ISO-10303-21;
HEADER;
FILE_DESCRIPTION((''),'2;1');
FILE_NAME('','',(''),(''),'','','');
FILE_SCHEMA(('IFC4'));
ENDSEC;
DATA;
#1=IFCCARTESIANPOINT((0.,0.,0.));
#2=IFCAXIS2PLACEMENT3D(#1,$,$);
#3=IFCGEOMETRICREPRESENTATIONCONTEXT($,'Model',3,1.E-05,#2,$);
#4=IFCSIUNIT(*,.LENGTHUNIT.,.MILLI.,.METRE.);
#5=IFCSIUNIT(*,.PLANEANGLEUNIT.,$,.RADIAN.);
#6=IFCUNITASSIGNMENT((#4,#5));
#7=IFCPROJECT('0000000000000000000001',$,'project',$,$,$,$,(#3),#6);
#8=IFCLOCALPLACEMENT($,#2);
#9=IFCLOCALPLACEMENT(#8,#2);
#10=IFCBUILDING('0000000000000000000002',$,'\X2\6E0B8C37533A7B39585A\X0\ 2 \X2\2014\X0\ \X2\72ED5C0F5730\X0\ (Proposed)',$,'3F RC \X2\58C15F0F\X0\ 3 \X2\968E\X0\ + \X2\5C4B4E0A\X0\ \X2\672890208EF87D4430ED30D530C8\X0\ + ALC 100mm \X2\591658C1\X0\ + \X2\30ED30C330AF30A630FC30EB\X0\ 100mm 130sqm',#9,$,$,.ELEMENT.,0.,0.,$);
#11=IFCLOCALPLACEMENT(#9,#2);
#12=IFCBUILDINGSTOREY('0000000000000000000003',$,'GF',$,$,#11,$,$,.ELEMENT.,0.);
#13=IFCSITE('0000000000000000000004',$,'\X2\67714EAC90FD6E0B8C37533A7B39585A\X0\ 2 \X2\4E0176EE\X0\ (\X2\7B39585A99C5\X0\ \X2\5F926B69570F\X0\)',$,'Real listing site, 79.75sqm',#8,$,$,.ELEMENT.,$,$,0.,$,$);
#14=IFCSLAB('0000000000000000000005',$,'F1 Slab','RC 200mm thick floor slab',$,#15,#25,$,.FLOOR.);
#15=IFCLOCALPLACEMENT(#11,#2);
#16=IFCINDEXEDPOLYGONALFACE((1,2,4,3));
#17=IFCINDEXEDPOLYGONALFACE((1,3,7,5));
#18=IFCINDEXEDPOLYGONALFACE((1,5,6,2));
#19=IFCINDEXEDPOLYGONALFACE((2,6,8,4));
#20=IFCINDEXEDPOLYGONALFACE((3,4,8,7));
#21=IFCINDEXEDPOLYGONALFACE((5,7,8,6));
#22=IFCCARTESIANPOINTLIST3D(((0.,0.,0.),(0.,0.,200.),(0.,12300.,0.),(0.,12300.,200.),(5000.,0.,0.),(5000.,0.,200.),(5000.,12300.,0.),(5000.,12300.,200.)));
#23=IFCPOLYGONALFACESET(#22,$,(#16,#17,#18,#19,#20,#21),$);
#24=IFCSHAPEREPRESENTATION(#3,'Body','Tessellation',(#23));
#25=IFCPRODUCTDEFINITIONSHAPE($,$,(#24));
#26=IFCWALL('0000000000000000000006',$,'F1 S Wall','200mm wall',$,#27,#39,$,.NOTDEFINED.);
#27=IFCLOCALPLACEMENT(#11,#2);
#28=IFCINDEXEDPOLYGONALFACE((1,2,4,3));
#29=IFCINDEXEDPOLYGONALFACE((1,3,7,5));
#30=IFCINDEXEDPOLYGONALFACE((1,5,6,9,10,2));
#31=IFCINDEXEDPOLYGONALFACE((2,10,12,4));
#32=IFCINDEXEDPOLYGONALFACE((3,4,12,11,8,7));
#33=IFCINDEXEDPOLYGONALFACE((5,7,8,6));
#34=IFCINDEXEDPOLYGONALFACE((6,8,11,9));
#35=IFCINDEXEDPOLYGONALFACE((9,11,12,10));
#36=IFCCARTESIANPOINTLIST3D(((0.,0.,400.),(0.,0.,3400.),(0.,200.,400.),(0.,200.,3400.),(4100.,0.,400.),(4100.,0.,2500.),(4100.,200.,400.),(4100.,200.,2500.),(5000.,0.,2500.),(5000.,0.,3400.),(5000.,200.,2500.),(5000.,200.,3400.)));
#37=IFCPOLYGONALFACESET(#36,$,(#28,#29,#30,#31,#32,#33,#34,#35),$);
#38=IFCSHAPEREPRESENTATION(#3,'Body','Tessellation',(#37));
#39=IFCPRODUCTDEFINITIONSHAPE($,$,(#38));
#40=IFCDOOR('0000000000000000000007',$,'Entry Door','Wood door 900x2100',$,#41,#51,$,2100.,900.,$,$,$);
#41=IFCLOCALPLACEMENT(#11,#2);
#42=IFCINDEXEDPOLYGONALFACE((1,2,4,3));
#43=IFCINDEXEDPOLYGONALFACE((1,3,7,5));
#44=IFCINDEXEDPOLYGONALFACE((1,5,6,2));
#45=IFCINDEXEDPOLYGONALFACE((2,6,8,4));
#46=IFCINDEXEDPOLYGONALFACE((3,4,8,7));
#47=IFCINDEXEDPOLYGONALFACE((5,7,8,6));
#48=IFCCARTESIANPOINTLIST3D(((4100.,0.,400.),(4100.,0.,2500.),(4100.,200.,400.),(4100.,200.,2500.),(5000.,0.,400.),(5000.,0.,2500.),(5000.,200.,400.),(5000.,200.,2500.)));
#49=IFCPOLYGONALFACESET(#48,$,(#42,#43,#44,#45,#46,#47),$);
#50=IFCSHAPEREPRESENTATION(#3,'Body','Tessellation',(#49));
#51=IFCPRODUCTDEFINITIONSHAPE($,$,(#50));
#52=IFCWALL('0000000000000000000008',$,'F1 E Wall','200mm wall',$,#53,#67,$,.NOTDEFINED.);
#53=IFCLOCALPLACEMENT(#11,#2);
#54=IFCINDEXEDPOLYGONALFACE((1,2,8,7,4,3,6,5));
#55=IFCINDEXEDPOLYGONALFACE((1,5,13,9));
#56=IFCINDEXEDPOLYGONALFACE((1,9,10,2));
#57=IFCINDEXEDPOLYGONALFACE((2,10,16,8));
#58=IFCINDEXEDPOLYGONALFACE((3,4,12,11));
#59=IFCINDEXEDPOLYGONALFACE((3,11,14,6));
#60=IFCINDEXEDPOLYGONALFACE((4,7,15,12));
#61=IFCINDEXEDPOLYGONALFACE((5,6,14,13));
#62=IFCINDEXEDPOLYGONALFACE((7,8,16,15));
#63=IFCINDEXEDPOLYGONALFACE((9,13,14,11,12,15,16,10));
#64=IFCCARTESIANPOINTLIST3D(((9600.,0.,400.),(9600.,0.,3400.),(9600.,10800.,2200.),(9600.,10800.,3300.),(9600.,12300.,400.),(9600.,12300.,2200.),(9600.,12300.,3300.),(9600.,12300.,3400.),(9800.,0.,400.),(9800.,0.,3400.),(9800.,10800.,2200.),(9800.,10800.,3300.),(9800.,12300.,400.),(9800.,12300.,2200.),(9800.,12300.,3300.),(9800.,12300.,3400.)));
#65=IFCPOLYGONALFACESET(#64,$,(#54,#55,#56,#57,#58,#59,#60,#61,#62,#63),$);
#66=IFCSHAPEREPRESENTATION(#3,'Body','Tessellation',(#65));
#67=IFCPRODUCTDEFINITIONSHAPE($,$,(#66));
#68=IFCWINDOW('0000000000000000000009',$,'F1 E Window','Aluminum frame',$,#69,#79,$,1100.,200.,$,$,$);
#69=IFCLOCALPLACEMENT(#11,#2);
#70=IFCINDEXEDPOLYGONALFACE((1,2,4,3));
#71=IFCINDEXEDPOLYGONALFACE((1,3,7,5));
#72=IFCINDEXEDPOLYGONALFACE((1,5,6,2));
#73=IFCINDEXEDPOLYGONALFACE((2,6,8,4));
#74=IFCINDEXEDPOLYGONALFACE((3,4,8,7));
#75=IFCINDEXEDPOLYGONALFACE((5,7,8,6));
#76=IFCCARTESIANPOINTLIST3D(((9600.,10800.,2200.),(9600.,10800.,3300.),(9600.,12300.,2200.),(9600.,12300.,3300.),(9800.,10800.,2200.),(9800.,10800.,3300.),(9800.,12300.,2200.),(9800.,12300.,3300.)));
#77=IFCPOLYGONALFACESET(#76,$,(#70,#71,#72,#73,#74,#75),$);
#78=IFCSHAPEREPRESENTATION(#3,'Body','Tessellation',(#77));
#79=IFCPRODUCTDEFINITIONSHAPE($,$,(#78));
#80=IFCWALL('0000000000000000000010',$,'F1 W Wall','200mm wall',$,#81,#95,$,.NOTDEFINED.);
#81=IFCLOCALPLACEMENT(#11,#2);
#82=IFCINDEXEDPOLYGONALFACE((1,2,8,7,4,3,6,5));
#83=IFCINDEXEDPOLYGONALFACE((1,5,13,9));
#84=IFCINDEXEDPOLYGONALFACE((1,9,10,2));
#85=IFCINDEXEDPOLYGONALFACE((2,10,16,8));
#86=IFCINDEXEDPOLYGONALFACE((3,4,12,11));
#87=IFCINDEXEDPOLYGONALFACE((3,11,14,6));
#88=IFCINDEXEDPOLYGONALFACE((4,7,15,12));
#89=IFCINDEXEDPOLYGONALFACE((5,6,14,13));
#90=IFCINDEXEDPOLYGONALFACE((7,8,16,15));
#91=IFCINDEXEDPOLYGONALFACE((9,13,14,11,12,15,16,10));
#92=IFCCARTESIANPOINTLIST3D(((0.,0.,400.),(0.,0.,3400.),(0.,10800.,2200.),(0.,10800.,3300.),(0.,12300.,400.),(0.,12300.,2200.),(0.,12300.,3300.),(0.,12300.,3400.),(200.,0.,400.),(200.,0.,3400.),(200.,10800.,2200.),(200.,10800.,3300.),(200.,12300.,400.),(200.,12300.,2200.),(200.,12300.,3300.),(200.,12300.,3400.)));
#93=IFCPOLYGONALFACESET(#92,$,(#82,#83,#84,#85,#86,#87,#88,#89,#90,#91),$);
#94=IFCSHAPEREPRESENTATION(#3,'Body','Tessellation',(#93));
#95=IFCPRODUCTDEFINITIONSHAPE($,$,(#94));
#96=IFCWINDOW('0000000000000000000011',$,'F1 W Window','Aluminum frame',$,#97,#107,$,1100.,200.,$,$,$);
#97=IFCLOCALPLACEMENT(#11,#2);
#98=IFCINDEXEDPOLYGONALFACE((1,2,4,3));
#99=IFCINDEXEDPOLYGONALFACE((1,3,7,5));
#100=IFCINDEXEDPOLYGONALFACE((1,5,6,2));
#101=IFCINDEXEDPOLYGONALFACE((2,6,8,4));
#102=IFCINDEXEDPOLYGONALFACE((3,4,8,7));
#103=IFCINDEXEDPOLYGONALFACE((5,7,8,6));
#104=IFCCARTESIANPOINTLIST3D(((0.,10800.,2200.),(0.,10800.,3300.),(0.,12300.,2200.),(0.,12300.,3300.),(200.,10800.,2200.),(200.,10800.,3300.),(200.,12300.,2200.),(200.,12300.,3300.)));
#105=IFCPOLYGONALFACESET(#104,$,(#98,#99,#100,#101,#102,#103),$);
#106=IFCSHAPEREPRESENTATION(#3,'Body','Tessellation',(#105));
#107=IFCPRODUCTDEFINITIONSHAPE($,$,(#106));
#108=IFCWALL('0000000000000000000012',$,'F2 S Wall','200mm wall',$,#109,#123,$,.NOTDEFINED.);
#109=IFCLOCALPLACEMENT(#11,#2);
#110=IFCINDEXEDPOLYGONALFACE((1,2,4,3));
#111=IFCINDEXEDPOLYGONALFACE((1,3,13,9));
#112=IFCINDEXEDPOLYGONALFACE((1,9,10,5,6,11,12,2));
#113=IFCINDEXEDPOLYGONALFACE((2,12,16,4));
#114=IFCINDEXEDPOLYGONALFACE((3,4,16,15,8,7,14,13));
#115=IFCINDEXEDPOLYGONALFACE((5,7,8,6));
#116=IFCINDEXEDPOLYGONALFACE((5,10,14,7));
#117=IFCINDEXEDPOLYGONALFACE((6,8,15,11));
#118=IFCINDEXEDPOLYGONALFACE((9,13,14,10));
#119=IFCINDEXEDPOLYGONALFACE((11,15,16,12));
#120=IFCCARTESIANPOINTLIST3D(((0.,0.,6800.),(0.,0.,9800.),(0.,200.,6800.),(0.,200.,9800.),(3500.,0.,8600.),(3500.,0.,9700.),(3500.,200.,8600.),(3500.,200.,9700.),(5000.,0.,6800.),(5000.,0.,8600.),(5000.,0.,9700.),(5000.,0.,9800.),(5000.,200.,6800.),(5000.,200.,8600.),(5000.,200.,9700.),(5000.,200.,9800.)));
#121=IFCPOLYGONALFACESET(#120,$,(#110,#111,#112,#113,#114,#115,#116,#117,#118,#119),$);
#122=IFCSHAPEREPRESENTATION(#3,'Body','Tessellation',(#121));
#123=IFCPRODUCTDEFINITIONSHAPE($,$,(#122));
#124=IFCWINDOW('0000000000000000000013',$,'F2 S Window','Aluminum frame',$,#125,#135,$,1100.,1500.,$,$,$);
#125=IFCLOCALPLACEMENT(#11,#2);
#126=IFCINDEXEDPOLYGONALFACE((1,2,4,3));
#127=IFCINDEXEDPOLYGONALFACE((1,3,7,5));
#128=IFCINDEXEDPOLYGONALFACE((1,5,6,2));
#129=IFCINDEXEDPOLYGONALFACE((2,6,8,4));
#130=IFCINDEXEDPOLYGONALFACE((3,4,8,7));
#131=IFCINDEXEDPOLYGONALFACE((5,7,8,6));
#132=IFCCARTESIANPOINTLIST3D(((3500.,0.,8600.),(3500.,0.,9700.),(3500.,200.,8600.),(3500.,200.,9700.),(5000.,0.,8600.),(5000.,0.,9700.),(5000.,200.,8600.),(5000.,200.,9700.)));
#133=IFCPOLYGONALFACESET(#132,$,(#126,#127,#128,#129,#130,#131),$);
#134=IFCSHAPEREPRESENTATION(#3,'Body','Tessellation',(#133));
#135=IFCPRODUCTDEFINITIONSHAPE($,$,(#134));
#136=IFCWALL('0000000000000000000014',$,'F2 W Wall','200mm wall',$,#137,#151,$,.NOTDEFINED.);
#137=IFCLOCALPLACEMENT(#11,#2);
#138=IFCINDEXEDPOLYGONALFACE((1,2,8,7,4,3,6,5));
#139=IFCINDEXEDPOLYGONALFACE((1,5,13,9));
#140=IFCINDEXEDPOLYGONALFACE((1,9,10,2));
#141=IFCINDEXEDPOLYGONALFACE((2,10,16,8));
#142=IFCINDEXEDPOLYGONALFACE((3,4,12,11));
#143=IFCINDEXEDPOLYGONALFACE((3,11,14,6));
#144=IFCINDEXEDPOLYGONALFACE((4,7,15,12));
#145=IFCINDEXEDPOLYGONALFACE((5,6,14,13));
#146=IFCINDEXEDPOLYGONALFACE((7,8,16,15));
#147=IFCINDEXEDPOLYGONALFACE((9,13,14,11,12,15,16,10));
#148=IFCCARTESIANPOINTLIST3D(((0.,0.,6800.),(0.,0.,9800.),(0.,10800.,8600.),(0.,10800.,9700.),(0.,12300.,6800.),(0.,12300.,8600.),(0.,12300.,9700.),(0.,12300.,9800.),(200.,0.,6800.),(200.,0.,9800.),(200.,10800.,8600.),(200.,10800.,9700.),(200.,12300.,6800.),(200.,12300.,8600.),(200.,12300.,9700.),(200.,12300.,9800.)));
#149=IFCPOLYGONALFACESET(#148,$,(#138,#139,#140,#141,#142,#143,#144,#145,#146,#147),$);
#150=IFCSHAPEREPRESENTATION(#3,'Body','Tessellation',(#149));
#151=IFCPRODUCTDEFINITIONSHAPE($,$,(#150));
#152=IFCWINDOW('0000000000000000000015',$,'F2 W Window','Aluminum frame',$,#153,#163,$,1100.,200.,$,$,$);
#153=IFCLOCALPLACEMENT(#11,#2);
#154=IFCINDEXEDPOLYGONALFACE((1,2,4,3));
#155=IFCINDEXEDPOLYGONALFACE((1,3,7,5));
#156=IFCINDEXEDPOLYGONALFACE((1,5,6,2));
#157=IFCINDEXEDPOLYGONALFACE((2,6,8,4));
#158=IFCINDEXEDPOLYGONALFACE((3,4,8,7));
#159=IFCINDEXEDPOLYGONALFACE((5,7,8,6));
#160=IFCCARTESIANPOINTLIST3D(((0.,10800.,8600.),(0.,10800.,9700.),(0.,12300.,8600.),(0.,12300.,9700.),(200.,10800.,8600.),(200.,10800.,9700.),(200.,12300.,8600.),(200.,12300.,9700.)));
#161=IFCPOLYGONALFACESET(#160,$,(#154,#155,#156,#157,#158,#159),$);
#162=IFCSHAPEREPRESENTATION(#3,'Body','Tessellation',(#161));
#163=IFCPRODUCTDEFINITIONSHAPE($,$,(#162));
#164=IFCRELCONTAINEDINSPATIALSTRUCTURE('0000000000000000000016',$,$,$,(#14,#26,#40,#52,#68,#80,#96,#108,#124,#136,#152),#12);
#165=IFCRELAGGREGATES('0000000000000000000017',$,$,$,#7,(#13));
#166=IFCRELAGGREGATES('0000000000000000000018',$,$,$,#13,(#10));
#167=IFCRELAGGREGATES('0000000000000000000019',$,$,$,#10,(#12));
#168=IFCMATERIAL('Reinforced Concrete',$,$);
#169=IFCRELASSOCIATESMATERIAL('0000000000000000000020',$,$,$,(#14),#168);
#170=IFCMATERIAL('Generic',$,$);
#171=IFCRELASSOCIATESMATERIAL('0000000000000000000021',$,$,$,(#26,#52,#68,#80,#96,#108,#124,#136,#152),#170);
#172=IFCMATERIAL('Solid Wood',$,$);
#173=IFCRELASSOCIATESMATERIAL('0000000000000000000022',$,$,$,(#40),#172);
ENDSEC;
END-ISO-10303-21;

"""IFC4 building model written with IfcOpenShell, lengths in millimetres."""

from ifc_helpers import new_model, si_unit, frame, frame_2d, origin, place, context, project, spatial, rectangle, extrude, material, element, fill, save


model = new_model("IFC4")

# Units and contexts
model_context = context("Model", 3, precision=1e-05, world=origin())
ifc_project = project(units=[si_unit("LENGTHUNIT", "METRE", prefix="MILLI"), si_unit("PLANEANGLEUNIT", "RADIAN")], contexts=[model_context])

# Site, building, storey
site_placement = place(None, origin())
site = spatial("IfcSite", under=ifc_project, at=site_placement, Name="東京都渋谷区笹塚 2 丁目 (笹塚駅 徒歩圏)", ObjectType="Real listing site, 79.75sqm", CompositionType="ELEMENT", RefElevation=0.0)
building_placement = place(site_placement, origin())
building = spatial("IfcBuilding", under=site, at=building_placement, Name="渋谷区笹塚 2 — 狭小地 (Proposed)", ObjectType="3F RC 壁式 3 階 + 屋上 木造軸組ロフト + ALC 100mm 外壁 + ロックウール 100mm 130sqm", CompositionType="ELEMENT", ElevationOfRefHeight=0.0, ElevationOfTerrain=0.0)
storey_placement = place(building_placement, origin())
storey = spatial("IfcBuildingStorey", under=building, at=storey_placement, Name="GF", CompositionType="ELEMENT", Elevation=0.0)

# Slab
ifc_material_1 = material(Name="Reinforced Concrete")
slab_1_placement = place(storey_placement, origin())
element("IfcSlab", 1, at=slab_1_placement, inside=storey, material=ifc_material_1, Name="F1 Slab", Description="RC 200mm thick floor slab", PredefinedType="FLOOR", context=model_context, shape_type="SweptSolid", body=[
    extrude(rectangle(XDim=5000.0, YDim=12300.0, at=frame_2d((2500.0, 6150.0))), origin(), (0.0, 0.0, 1.0), 200.0),
])

# Wall, opening, door
ifc_material_2 = material(Name="Generic")
wall_1_placement = place(storey_placement, frame((0.0, 0.0, 200.0)))
wall_1 = element("IfcWall", 2, at=wall_1_placement, inside=storey, material=ifc_material_2, Name="F1 S Wall", Description="200mm wall", PredefinedType="NOTDEFINED", context=model_context, shape_type="SweptSolid", body=[
    extrude(rectangle(XDim=5000.0, YDim=200.0, at=frame_2d((2500.0, 100.0))), frame((0.0, 0.0, 200.0)), (0.0, 0.0, 1.0), 3000.0),
])
opening_1_placement = place(storey_placement, frame((2050.0, 0.0, 200.0)))
opening_1 = element("IfcOpeningElement", 3, at=opening_1_placement, cuts=wall_1, PredefinedType="NOTDEFINED", context=model_context, shape_type="SweptSolid", body=[
    extrude(rectangle(XDim=900.0, YDim=200.0, at=frame_2d((450.0, 100.0))), frame((2050.0, 0.0, 200.0)), (0.0, 0.0, 1.0), 2100.0),
])
ifc_material_3 = material(Name="Solid Wood")
door_placement = place(storey_placement, frame((2050.0, 0.0, 200.0)))
door = element("IfcDoor", 4, at=door_placement, inside=storey, material=ifc_material_3, Name="Entry Door", Description="Wood door 900x2100", OverallHeight=2100.0, OverallWidth=900.0, context=model_context, shape_type="SweptSolid", body=[
    extrude(rectangle(XDim=900.0, YDim=200.0, at=frame_2d((450.0, 100.0))), frame((2050.0, 0.0, 200.0)), (0.0, 0.0, 1.0), 2100.0),
])
fill(opening_1, door)

# Walls, openings, windows
wall_2_placement = place(storey_placement, frame((4800.0, 0.0, 200.0)))
wall_2 = element("IfcWall", 5, at=wall_2_placement, inside=storey, material=ifc_material_2, Name="F1 E Wall", Description="200mm wall", PredefinedType="NOTDEFINED", context=model_context, shape_type="SweptSolid", body=[
    extrude(rectangle(XDim=200.0, YDim=12300.0, at=frame_2d((100.0, 6150.0))), frame((4800.0, 0.0, 200.0)), (0.0, 0.0, 1.0), 3000.0),
])
opening_2_placement = place(storey_placement, frame((4800.0, 5400.0, 1100.0)))
opening_2 = element("IfcOpeningElement", 6, at=opening_2_placement, cuts=wall_2, PredefinedType="NOTDEFINED", context=model_context, shape_type="SweptSolid", body=[
    extrude(rectangle(XDim=200.0, YDim=1500.0, at=frame_2d((100.0, 750.0))), frame((4800.0, 5400.0, 1100.0)), (0.0, 0.0, 1.0), 1100.0),
])
window_1_placement = place(storey_placement, frame((4800.0, 5400.0, 1100.0)))
window_1 = element("IfcWindow", 7, at=window_1_placement, inside=storey, material=ifc_material_2, Name="F1 E Window", Description="Aluminum frame", OverallHeight=1100.0, OverallWidth=200.0, context=model_context, shape_type="SweptSolid", body=[
    extrude(rectangle(XDim=200.0, YDim=1500.0, at=frame_2d((100.0, 750.0))), frame((4800.0, 5400.0, 1100.0)), (0.0, 0.0, 1.0), 1100.0),
])
fill(opening_2, window_1)
wall_3_placement = place(storey_placement, frame((0.0, 0.0, 200.0)))
wall_3 = element("IfcWall", 8, at=wall_3_placement, inside=storey, material=ifc_material_2, Name="F1 W Wall", Description="200mm wall", PredefinedType="NOTDEFINED", context=model_context, shape_type="SweptSolid", body=[
    extrude(rectangle(XDim=200.0, YDim=12300.0, at=frame_2d((100.0, 6150.0))), frame((0.0, 0.0, 200.0)), (0.0, 0.0, 1.0), 3000.0),
])
opening_3_placement = place(storey_placement, frame((0.0, 5400.0, 1100.0)))
opening_3 = element("IfcOpeningElement", 9, at=opening_3_placement, cuts=wall_3, PredefinedType="NOTDEFINED", context=model_context, shape_type="SweptSolid", body=[
    extrude(rectangle(XDim=200.0, YDim=1500.0, at=frame_2d((100.0, 750.0))), frame((0.0, 5400.0, 1100.0)), (0.0, 0.0, 1.0), 1100.0),
])
window_2_placement = place(storey_placement, frame((0.0, 5400.0, 1100.0)))
window_2 = element("IfcWindow", 10, at=window_2_placement, inside=storey, material=ifc_material_2, Name="F1 W Window", Description="Aluminum frame", OverallHeight=1100.0, OverallWidth=200.0, context=model_context, shape_type="SweptSolid", body=[
    extrude(rectangle(XDim=200.0, YDim=1500.0, at=frame_2d((100.0, 750.0))), frame((0.0, 5400.0, 1100.0)), (0.0, 0.0, 1.0), 1100.0),
])
fill(opening_3, window_2)
wall_4_placement = place(storey_placement, frame((0.0, 0.0, 3400.0)))
wall_4 = element("IfcWall", 11, at=wall_4_placement, inside=storey, material=ifc_material_2, Name="F2 S Wall", Description="200mm wall", PredefinedType="NOTDEFINED", context=model_context, shape_type="SweptSolid", body=[
    extrude(rectangle(XDim=5000.0, YDim=200.0, at=frame_2d((2500.0, 100.0))), frame((0.0, 0.0, 3400.0)), (0.0, 0.0, 1.0), 3000.0),
])
opening_4_placement = place(storey_placement, frame((1750.0, 0.0, 4300.0)))
opening_4 = element("IfcOpeningElement", 12, at=opening_4_placement, cuts=wall_4, PredefinedType="NOTDEFINED", context=model_context, shape_type="SweptSolid", body=[
    extrude(rectangle(XDim=1500.0, YDim=200.0, at=frame_2d((750.0, 100.0))), frame((1750.0, 0.0, 4300.0)), (0.0, 0.0, 1.0), 1100.0),
])
window_3_placement = place(storey_placement, frame((1750.0, 0.0, 4300.0)))
window_3 = element("IfcWindow", 13, at=window_3_placement, inside=storey, material=ifc_material_2, Name="F2 S Window", Description="Aluminum frame", OverallHeight=1100.0, OverallWidth=1500.0, context=model_context, shape_type="SweptSolid", body=[
    extrude(rectangle(XDim=1500.0, YDim=200.0, at=frame_2d((750.0, 100.0))), frame((1750.0, 0.0, 4300.0)), (0.0, 0.0, 1.0), 1100.0),
])
fill(opening_4, window_3)
wall_5_placement = place(storey_placement, frame((0.0, 0.0, 3400.0)))
wall_5 = element("IfcWall", 14, at=wall_5_placement, inside=storey, material=ifc_material_2, Name="F2 W Wall", Description="200mm wall", PredefinedType="NOTDEFINED", context=model_context, shape_type="SweptSolid", body=[
    extrude(rectangle(XDim=200.0, YDim=12300.0, at=frame_2d((100.0, 6150.0))), frame((0.0, 0.0, 3400.0)), (0.0, 0.0, 1.0), 3000.0),
])
opening_5_placement = place(storey_placement, frame((0.0, 5400.0, 4300.0)))
opening_5 = element("IfcOpeningElement", 15, at=opening_5_placement, cuts=wall_5, PredefinedType="NOTDEFINED", context=model_context, shape_type="SweptSolid", body=[
    extrude(rectangle(XDim=200.0, YDim=1500.0, at=frame_2d((100.0, 750.0))), frame((0.0, 5400.0, 4300.0)), (0.0, 0.0, 1.0), 1100.0),
])
window_4_placement = place(storey_placement, frame((0.0, 5400.0, 4300.0)))
window_4 = element("IfcWindow", 16, at=window_4_placement, inside=storey, material=ifc_material_2, Name="F2 W Window", Description="Aluminum frame", OverallHeight=1100.0, OverallWidth=200.0, context=model_context, shape_type="SweptSolid", body=[
    extrude(rectangle(XDim=200.0, YDim=1500.0, at=frame_2d((100.0, 750.0))), frame((0.0, 5400.0, 4300.0)), (0.0, 0.0, 1.0), 1100.0),
])
fill(opening_5, window_4)

save(model, "model.ifc")
